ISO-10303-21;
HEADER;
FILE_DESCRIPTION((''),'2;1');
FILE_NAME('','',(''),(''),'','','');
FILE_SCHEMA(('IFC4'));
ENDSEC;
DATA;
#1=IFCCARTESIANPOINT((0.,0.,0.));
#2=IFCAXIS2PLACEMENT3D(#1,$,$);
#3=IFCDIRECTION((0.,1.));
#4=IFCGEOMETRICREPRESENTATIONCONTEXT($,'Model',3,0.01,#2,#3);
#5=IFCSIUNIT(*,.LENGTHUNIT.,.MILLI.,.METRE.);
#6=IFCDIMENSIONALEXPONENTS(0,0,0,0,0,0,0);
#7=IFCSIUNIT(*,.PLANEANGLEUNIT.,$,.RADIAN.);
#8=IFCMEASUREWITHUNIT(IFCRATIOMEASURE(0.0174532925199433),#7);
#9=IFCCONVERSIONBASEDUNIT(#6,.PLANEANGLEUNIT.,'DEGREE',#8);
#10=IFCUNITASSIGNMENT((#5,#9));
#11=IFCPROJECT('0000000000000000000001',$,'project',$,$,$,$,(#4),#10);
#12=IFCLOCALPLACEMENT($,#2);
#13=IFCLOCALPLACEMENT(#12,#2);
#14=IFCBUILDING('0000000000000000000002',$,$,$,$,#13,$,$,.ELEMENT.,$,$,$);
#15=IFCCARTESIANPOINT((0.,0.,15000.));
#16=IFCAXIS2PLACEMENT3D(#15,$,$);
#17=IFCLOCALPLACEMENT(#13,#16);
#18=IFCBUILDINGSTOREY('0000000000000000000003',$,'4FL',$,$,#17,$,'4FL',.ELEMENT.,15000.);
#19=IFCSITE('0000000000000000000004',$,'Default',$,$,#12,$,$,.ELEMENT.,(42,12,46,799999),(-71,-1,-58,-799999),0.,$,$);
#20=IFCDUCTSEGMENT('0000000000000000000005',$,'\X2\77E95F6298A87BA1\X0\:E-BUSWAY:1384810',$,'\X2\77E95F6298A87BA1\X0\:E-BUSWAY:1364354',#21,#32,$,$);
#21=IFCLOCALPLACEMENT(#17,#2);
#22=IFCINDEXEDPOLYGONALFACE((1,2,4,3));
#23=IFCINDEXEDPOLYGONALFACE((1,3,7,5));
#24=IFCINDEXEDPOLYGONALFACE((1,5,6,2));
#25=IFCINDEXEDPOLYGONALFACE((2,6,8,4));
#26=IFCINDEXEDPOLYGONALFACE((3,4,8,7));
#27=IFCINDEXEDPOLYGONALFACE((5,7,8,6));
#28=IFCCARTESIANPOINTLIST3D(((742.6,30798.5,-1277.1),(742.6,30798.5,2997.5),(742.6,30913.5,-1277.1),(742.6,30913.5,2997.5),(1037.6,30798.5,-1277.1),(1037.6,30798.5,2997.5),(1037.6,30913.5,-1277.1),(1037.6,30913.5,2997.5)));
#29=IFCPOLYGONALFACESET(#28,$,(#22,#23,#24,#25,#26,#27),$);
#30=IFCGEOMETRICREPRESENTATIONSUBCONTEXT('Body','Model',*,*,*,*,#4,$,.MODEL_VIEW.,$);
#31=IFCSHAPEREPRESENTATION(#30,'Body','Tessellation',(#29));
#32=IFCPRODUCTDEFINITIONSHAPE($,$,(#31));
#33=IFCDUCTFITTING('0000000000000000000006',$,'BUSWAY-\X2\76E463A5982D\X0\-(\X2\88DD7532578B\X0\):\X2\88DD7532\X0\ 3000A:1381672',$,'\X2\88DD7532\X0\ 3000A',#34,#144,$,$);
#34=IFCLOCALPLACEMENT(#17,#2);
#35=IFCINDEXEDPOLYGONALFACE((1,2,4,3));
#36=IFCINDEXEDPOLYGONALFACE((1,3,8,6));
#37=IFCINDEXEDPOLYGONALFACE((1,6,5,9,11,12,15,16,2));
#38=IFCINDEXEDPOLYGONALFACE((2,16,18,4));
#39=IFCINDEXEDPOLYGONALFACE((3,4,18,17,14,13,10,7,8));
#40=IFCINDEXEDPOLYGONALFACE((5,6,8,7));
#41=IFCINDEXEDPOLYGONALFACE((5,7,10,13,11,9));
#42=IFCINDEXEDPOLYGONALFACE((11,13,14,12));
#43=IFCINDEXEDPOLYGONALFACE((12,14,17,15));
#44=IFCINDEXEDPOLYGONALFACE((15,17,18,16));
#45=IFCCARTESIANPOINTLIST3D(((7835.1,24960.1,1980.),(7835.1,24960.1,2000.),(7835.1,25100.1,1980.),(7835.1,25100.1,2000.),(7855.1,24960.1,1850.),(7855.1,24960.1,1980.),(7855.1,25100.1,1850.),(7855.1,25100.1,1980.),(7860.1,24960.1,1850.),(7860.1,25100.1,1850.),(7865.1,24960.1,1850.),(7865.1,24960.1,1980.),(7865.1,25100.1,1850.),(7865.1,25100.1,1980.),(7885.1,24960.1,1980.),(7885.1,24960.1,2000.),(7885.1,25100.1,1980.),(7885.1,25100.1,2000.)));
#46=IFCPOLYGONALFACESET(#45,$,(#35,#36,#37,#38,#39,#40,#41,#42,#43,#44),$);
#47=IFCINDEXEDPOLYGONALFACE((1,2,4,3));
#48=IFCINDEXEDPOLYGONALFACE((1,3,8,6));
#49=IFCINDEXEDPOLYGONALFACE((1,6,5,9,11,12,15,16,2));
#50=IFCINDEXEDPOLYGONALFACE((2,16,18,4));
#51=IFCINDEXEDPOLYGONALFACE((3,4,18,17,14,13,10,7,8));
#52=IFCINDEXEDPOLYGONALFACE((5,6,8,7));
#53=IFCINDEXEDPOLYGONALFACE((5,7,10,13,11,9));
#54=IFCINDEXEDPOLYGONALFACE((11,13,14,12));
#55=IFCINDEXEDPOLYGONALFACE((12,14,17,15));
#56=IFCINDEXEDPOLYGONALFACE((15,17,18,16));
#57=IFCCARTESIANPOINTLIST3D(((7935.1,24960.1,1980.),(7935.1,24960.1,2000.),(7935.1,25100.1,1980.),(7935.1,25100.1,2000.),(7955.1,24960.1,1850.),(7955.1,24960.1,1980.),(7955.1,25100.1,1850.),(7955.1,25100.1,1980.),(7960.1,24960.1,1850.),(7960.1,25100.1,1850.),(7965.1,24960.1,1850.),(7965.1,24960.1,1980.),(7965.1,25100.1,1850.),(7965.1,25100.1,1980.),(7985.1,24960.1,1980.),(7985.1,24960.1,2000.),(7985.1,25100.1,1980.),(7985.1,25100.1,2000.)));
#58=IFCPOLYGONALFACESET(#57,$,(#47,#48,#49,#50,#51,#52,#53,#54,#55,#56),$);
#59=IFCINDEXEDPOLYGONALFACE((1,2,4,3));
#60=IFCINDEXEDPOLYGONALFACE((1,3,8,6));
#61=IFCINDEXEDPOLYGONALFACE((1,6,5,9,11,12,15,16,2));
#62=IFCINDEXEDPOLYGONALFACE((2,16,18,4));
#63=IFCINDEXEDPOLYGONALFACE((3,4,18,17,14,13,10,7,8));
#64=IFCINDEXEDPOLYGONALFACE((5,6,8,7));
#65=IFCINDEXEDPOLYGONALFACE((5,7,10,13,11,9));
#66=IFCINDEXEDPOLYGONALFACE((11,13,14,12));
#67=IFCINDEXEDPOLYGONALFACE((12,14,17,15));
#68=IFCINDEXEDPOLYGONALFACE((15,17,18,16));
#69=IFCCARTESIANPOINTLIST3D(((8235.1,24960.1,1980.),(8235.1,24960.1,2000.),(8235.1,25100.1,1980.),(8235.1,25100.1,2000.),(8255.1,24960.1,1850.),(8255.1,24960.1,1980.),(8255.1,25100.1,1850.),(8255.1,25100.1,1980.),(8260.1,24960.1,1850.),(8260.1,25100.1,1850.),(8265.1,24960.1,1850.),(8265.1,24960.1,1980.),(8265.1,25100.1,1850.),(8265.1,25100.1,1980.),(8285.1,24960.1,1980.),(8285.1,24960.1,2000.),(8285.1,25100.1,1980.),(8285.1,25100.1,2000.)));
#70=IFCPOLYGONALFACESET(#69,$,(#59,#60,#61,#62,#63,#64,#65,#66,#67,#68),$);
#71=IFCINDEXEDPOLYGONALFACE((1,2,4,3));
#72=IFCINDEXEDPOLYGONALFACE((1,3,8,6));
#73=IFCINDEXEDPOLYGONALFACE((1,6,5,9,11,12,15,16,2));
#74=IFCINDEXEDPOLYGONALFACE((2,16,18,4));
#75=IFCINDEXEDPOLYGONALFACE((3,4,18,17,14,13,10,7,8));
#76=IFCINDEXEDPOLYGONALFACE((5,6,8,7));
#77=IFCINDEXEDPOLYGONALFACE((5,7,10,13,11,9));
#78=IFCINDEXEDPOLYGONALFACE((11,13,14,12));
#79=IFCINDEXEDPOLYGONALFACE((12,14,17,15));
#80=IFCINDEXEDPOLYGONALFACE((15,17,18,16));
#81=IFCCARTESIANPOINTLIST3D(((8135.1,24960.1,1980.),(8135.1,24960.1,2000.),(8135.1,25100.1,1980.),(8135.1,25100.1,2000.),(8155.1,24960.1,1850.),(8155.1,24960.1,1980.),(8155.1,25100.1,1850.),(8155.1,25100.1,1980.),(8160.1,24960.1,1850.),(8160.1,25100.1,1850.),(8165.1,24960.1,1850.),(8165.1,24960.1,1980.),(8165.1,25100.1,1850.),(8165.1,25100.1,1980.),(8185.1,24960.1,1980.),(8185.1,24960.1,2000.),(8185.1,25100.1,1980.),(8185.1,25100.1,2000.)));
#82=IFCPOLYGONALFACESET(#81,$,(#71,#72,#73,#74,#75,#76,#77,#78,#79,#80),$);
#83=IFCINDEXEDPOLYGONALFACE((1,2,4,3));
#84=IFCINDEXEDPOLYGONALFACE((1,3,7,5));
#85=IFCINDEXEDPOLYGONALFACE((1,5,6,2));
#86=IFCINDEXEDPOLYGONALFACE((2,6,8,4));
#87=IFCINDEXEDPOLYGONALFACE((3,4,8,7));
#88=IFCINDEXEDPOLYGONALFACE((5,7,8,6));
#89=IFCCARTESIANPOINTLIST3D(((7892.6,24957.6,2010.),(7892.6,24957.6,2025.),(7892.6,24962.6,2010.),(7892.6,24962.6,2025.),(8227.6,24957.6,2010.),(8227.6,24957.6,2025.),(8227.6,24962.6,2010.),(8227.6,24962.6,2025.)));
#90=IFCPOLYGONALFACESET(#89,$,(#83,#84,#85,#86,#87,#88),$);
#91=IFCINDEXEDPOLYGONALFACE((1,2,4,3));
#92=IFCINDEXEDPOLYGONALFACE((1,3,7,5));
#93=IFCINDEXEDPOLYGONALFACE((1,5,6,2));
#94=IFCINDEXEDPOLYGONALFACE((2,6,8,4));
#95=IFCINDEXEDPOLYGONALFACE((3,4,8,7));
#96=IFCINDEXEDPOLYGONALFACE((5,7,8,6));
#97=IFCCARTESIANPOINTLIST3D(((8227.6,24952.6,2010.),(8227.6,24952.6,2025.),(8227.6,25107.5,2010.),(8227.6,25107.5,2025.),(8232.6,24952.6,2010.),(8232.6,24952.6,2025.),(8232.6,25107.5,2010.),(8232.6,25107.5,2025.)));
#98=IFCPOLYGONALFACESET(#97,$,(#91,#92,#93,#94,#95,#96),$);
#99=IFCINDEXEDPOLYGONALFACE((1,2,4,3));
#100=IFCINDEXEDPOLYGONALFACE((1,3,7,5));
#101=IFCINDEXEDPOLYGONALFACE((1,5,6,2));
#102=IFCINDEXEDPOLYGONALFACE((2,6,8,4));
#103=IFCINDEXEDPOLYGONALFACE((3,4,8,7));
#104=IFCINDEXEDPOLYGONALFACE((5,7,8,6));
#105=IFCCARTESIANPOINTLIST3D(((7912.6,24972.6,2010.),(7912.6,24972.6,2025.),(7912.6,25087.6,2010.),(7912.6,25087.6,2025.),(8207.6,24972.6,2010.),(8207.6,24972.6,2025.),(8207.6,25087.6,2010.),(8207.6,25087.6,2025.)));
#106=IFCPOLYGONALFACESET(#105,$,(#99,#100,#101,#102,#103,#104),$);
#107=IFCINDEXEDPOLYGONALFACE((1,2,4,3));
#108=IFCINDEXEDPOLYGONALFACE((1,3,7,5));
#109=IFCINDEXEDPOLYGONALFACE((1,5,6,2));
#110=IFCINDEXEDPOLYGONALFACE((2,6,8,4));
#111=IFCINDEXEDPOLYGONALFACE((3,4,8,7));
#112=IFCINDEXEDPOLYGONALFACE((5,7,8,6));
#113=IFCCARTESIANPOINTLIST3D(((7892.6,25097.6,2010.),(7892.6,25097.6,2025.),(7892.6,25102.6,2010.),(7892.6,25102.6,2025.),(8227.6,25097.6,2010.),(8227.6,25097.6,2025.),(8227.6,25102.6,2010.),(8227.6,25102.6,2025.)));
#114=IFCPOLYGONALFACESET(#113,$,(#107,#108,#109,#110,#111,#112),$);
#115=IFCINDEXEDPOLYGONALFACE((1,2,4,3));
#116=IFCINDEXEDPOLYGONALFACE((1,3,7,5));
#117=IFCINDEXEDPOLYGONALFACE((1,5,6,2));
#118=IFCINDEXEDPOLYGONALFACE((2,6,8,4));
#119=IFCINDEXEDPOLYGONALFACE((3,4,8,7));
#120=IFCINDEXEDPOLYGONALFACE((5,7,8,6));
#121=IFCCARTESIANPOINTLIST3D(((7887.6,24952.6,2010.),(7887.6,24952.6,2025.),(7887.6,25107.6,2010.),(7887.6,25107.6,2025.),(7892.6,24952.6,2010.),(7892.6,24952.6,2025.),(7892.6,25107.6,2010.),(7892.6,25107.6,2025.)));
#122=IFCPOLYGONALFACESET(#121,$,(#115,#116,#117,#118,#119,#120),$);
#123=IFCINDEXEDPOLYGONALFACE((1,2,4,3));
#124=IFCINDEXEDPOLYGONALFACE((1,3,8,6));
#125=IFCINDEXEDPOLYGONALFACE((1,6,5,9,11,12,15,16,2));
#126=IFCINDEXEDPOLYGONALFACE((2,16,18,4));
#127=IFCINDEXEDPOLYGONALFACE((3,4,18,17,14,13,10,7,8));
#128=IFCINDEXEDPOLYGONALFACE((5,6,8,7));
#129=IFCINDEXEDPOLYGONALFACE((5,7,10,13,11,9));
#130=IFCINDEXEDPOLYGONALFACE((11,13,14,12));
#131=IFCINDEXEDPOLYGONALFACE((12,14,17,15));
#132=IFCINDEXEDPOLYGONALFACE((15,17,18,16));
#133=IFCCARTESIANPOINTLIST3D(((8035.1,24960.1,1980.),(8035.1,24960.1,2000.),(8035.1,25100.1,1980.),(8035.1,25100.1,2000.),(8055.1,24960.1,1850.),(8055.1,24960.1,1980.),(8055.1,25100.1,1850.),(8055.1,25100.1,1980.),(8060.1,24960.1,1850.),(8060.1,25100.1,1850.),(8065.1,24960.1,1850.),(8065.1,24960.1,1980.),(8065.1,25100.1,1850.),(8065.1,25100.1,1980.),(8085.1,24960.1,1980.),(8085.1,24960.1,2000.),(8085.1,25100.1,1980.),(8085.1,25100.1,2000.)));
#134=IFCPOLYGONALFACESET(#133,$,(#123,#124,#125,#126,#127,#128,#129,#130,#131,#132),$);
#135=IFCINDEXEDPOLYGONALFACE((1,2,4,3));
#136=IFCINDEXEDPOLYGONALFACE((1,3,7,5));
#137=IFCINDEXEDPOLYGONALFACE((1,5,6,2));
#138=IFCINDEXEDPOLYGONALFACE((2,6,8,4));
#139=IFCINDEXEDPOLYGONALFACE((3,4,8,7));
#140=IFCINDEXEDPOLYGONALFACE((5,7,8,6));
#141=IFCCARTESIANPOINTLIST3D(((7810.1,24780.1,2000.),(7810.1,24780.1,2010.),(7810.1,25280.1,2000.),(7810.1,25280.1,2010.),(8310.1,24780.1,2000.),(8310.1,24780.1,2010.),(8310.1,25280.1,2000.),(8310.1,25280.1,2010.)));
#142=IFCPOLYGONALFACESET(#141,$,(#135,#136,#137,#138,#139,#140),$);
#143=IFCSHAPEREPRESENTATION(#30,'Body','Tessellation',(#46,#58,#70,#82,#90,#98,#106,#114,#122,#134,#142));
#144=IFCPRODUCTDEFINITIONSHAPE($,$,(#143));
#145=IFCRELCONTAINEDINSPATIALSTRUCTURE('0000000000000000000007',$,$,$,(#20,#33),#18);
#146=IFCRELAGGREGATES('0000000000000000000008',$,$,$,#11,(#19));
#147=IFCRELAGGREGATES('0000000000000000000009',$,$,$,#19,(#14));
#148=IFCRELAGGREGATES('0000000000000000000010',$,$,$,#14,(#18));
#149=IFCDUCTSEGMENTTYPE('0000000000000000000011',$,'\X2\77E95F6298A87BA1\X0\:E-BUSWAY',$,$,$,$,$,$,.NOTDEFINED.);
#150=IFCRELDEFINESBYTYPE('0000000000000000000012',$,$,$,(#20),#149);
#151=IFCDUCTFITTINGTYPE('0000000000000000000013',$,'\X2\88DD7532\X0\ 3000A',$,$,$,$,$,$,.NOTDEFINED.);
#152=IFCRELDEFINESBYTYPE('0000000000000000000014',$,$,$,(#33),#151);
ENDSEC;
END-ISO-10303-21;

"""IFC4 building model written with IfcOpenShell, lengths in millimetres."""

from ifc_helpers import new_model, entity, si_unit, converted_unit, direction, frame, frame_2d, origin, origin_2d_with_axis, place, context, subcontext, project, spatial, polyline, rectangle, outline, extrude, source, transform, mapped, type_object, type_shapes, element, save


model = new_model("IFC4")

# Units and contexts
model_context = context("Model", 3, precision=0.01, world=origin(), true_north=direction((0.0, 1.0)))
body_context = subcontext(model_context, "Body", "Model", "MODEL_VIEW")
ifc_project = project(units=[si_unit("LENGTHUNIT", "METRE", prefix="MILLI"), converted_unit("PLANEANGLEUNIT", "DEGREE", entity("IfcRatioMeasure", 0.0174532925199433), si_unit("PLANEANGLEUNIT", "RADIAN"), dimensions=[0, 0, 0, 0, 0, 0, 0])], contexts=[model_context])

# Site, building, storey
site_placement = place(None, origin())
site = spatial("IfcSite", under=ifc_project, at=site_placement, Name="Default", CompositionType="ELEMENT", RefLatitude=(42, 12, 46, 799999), RefLongitude=(-71, -1, -58, -799999), RefElevation=0.0)
building_placement = place(site_placement, origin())
building = spatial("IfcBuilding", under=site, at=building_placement, CompositionType="ELEMENT")
storey_placement = place(building_placement, frame((0.0, 0.0, 15000.0)))
storey = spatial("IfcBuildingStorey", under=building, at=storey_placement, Name="4FL", LongName="4FL", CompositionType="ELEMENT", Elevation=15000.0)

# Duct segment
duct_segment_type = type_object("IfcDuctSegmentType", Name="矩形風管:E-BUSWAY", PredefinedType="NOTDEFINED")
duct_segment_1_placement = place(storey_placement, frame((742.6, 30798.5, -1277.1)))
element("IfcDuctSegment", 1, at=duct_segment_1_placement, inside=storey, type_object=duct_segment_type, Name="矩形風管:E-BUSWAY:1384810", ObjectType="矩形風管:E-BUSWAY:1364354", context=body_context, shape_type="SweptSolid", body=[
    extrude(rectangle(XDim=295.0, YDim=115.0, at=frame_2d((0.0, 0.0), x_axis=(1.0, 0.0))), frame((147.5, 57.5, 0.0), z_axis=(0.0, 0.0, 1.0), x_axis=(-1.0, 0.0, 0.0)), (0.0, 0.0, 1.0), 4274.6),
])

# Duct fitting
duct_fitting_type_1 = type_object("IfcDuctFittingType", Name="裝甲 3000A", PredefinedType="NOTDEFINED")
shared_shape_1 = source(origin(), body_context, "Body", "SweptSolid", [
    extrude(outline(polyline([(-25.0, -58.9), (25.0, -58.9), (25.0, -38.9), (5.0, -38.9), (5.0, 91.1), (0.0, 91.1), (-5.0, 91.1), (-5.0, -38.9), (-25.0, -38.9), (-25.0, -58.9)])), frame((-200.0, -70.0, -58.9), z_axis=(0.0, 1.0, 0.0), x_axis=(1.0, 0.0, 0.0)), (0.0, 0.0, 1.0), 140.0),
    extrude(outline(polyline([(-25.0, -58.9), (25.0, -58.9), (25.0, -38.9), (5.0, -38.9), (5.0, 91.1), (0.0, 91.1), (-5.0, 91.1), (-5.0, -38.9), (-25.0, -38.9), (-25.0, -58.9)])), frame((-100.0, -70.0, -58.9), z_axis=(0.0, 1.0, 0.0), x_axis=(1.0, 0.0, 0.0)), (0.0, 0.0, 1.0), 140.0),
    extrude(outline(polyline([(-58.9, -25.0), (-38.9, -25.0), (-38.9, -5.0), (91.1, -5.0), (91.1, 0.0), (91.1, 5.0), (-38.9, 5.0), (-38.9, 25.0), (-58.9, 25.0), (-58.9, -25.0)])), frame((200.0, -70.0, -58.9), z_axis=(0.0, 1.0, 0.0), x_axis=(0.0, 0.0, -1.0)), (0.0, 0.0, 1.0), 140.0),
    extrude(outline(polyline([(-58.9, -25.0), (-38.9, -25.0), (-38.9, -5.0), (91.1, -5.0), (91.1, 0.0), (91.1, 5.0), (-38.9, 5.0), (-38.9, 25.0), (-58.9, 25.0), (-58.9, -25.0)])), frame((100.0, -70.0, -58.9), z_axis=(0.0, 1.0, 0.0), x_axis=(0.0, 0.0, -1.0)), (0.0, 0.0, 1.0), 140.0),
    extrude(rectangle(XDim=335.0, YDim=5.0, at=origin_2d_with_axis()), frame((0.0, -70.0, 10.0), z_axis=(0.0, 0.0, 1.0), x_axis=(-1.0, 0.0, 0.0)), (0.0, 0.0, 1.0), 15.0),
    extrude(rectangle(XDim=5.0, YDim=154.9, at=frame_2d((0.0, 0.0), x_axis=(1.0, 0.0))), frame((170.0, -0.1, 10.0), z_axis=(0.0, 0.0, 1.0), x_axis=(-1.0, 0.0, 0.0)), (0.0, 0.0, 1.0), 15.0),
    extrude(rectangle(XDim=295.0, YDim=115.0, at=origin_2d_with_axis()), frame((0.0, 0.0, 10.0), z_axis=(0.0, 0.0, 1.0), x_axis=(-1.0, 0.0, 0.0)), (0.0, 0.0, 1.0), 15.0),
    extrude(rectangle(XDim=335.0, YDim=5.0, at=origin_2d_with_axis()), frame((0.0, 70.0, 10.0), z_axis=(0.0, 0.0, 1.0), x_axis=(-1.0, 0.0, 0.0)), (0.0, 0.0, 1.0), 15.0),
    extrude(rectangle(XDim=5.0, YDim=155.0, at=origin_2d_with_axis()), frame((-170.0, 0.0, 10.0), z_axis=(0.0, 0.0, 1.0), x_axis=(-1.0, 0.0, 0.0)), (0.0, 0.0, 1.0), 15.0),
    extrude(outline(polyline([(-58.9, -25.0), (-38.9, -25.0), (-38.9, -5.0), (91.1, -5.0), (91.1, 0.0), (91.1, 5.0), (-38.9, 5.0), (-38.9, 25.0), (-58.9, 25.0), (-58.9, -25.0)])), frame((0.0, -70.0, -58.9), z_axis=(0.0, 1.0, 0.0), x_axis=(0.0, 0.0, -1.0)), (0.0, 0.0, 1.0), 140.0),
    extrude(rectangle(XDim=500.0, YDim=500.0, at=origin_2d_with_axis()), frame((0.0, 0.0, 0.0), z_axis=(0.0, 0.0, 1.0), x_axis=(0.0, 1.0, 0.0)), (0.0, 0.0, 1.0), 10.0),
])
type_shapes(duct_fitting_type_1, [shared_shape_1])
duct_fitting_1_placement = place(storey_placement, frame((8060.1, 25030.1, 2000.0)))
element("IfcDuctFitting", 2, at=duct_fitting_1_placement, inside=storey, type_object=duct_fitting_type_1, Name="BUSWAY-盤接頭-(裝甲型):裝甲 3000A:1381672", ObjectType="裝甲 3000A", context=body_context, shape_type="MappedRepresentation", body=[
    mapped(shared_shape_1, transform((0.0, 0.0, 0.0), scale=1.0)),
])

save(model, "model.ifc")
